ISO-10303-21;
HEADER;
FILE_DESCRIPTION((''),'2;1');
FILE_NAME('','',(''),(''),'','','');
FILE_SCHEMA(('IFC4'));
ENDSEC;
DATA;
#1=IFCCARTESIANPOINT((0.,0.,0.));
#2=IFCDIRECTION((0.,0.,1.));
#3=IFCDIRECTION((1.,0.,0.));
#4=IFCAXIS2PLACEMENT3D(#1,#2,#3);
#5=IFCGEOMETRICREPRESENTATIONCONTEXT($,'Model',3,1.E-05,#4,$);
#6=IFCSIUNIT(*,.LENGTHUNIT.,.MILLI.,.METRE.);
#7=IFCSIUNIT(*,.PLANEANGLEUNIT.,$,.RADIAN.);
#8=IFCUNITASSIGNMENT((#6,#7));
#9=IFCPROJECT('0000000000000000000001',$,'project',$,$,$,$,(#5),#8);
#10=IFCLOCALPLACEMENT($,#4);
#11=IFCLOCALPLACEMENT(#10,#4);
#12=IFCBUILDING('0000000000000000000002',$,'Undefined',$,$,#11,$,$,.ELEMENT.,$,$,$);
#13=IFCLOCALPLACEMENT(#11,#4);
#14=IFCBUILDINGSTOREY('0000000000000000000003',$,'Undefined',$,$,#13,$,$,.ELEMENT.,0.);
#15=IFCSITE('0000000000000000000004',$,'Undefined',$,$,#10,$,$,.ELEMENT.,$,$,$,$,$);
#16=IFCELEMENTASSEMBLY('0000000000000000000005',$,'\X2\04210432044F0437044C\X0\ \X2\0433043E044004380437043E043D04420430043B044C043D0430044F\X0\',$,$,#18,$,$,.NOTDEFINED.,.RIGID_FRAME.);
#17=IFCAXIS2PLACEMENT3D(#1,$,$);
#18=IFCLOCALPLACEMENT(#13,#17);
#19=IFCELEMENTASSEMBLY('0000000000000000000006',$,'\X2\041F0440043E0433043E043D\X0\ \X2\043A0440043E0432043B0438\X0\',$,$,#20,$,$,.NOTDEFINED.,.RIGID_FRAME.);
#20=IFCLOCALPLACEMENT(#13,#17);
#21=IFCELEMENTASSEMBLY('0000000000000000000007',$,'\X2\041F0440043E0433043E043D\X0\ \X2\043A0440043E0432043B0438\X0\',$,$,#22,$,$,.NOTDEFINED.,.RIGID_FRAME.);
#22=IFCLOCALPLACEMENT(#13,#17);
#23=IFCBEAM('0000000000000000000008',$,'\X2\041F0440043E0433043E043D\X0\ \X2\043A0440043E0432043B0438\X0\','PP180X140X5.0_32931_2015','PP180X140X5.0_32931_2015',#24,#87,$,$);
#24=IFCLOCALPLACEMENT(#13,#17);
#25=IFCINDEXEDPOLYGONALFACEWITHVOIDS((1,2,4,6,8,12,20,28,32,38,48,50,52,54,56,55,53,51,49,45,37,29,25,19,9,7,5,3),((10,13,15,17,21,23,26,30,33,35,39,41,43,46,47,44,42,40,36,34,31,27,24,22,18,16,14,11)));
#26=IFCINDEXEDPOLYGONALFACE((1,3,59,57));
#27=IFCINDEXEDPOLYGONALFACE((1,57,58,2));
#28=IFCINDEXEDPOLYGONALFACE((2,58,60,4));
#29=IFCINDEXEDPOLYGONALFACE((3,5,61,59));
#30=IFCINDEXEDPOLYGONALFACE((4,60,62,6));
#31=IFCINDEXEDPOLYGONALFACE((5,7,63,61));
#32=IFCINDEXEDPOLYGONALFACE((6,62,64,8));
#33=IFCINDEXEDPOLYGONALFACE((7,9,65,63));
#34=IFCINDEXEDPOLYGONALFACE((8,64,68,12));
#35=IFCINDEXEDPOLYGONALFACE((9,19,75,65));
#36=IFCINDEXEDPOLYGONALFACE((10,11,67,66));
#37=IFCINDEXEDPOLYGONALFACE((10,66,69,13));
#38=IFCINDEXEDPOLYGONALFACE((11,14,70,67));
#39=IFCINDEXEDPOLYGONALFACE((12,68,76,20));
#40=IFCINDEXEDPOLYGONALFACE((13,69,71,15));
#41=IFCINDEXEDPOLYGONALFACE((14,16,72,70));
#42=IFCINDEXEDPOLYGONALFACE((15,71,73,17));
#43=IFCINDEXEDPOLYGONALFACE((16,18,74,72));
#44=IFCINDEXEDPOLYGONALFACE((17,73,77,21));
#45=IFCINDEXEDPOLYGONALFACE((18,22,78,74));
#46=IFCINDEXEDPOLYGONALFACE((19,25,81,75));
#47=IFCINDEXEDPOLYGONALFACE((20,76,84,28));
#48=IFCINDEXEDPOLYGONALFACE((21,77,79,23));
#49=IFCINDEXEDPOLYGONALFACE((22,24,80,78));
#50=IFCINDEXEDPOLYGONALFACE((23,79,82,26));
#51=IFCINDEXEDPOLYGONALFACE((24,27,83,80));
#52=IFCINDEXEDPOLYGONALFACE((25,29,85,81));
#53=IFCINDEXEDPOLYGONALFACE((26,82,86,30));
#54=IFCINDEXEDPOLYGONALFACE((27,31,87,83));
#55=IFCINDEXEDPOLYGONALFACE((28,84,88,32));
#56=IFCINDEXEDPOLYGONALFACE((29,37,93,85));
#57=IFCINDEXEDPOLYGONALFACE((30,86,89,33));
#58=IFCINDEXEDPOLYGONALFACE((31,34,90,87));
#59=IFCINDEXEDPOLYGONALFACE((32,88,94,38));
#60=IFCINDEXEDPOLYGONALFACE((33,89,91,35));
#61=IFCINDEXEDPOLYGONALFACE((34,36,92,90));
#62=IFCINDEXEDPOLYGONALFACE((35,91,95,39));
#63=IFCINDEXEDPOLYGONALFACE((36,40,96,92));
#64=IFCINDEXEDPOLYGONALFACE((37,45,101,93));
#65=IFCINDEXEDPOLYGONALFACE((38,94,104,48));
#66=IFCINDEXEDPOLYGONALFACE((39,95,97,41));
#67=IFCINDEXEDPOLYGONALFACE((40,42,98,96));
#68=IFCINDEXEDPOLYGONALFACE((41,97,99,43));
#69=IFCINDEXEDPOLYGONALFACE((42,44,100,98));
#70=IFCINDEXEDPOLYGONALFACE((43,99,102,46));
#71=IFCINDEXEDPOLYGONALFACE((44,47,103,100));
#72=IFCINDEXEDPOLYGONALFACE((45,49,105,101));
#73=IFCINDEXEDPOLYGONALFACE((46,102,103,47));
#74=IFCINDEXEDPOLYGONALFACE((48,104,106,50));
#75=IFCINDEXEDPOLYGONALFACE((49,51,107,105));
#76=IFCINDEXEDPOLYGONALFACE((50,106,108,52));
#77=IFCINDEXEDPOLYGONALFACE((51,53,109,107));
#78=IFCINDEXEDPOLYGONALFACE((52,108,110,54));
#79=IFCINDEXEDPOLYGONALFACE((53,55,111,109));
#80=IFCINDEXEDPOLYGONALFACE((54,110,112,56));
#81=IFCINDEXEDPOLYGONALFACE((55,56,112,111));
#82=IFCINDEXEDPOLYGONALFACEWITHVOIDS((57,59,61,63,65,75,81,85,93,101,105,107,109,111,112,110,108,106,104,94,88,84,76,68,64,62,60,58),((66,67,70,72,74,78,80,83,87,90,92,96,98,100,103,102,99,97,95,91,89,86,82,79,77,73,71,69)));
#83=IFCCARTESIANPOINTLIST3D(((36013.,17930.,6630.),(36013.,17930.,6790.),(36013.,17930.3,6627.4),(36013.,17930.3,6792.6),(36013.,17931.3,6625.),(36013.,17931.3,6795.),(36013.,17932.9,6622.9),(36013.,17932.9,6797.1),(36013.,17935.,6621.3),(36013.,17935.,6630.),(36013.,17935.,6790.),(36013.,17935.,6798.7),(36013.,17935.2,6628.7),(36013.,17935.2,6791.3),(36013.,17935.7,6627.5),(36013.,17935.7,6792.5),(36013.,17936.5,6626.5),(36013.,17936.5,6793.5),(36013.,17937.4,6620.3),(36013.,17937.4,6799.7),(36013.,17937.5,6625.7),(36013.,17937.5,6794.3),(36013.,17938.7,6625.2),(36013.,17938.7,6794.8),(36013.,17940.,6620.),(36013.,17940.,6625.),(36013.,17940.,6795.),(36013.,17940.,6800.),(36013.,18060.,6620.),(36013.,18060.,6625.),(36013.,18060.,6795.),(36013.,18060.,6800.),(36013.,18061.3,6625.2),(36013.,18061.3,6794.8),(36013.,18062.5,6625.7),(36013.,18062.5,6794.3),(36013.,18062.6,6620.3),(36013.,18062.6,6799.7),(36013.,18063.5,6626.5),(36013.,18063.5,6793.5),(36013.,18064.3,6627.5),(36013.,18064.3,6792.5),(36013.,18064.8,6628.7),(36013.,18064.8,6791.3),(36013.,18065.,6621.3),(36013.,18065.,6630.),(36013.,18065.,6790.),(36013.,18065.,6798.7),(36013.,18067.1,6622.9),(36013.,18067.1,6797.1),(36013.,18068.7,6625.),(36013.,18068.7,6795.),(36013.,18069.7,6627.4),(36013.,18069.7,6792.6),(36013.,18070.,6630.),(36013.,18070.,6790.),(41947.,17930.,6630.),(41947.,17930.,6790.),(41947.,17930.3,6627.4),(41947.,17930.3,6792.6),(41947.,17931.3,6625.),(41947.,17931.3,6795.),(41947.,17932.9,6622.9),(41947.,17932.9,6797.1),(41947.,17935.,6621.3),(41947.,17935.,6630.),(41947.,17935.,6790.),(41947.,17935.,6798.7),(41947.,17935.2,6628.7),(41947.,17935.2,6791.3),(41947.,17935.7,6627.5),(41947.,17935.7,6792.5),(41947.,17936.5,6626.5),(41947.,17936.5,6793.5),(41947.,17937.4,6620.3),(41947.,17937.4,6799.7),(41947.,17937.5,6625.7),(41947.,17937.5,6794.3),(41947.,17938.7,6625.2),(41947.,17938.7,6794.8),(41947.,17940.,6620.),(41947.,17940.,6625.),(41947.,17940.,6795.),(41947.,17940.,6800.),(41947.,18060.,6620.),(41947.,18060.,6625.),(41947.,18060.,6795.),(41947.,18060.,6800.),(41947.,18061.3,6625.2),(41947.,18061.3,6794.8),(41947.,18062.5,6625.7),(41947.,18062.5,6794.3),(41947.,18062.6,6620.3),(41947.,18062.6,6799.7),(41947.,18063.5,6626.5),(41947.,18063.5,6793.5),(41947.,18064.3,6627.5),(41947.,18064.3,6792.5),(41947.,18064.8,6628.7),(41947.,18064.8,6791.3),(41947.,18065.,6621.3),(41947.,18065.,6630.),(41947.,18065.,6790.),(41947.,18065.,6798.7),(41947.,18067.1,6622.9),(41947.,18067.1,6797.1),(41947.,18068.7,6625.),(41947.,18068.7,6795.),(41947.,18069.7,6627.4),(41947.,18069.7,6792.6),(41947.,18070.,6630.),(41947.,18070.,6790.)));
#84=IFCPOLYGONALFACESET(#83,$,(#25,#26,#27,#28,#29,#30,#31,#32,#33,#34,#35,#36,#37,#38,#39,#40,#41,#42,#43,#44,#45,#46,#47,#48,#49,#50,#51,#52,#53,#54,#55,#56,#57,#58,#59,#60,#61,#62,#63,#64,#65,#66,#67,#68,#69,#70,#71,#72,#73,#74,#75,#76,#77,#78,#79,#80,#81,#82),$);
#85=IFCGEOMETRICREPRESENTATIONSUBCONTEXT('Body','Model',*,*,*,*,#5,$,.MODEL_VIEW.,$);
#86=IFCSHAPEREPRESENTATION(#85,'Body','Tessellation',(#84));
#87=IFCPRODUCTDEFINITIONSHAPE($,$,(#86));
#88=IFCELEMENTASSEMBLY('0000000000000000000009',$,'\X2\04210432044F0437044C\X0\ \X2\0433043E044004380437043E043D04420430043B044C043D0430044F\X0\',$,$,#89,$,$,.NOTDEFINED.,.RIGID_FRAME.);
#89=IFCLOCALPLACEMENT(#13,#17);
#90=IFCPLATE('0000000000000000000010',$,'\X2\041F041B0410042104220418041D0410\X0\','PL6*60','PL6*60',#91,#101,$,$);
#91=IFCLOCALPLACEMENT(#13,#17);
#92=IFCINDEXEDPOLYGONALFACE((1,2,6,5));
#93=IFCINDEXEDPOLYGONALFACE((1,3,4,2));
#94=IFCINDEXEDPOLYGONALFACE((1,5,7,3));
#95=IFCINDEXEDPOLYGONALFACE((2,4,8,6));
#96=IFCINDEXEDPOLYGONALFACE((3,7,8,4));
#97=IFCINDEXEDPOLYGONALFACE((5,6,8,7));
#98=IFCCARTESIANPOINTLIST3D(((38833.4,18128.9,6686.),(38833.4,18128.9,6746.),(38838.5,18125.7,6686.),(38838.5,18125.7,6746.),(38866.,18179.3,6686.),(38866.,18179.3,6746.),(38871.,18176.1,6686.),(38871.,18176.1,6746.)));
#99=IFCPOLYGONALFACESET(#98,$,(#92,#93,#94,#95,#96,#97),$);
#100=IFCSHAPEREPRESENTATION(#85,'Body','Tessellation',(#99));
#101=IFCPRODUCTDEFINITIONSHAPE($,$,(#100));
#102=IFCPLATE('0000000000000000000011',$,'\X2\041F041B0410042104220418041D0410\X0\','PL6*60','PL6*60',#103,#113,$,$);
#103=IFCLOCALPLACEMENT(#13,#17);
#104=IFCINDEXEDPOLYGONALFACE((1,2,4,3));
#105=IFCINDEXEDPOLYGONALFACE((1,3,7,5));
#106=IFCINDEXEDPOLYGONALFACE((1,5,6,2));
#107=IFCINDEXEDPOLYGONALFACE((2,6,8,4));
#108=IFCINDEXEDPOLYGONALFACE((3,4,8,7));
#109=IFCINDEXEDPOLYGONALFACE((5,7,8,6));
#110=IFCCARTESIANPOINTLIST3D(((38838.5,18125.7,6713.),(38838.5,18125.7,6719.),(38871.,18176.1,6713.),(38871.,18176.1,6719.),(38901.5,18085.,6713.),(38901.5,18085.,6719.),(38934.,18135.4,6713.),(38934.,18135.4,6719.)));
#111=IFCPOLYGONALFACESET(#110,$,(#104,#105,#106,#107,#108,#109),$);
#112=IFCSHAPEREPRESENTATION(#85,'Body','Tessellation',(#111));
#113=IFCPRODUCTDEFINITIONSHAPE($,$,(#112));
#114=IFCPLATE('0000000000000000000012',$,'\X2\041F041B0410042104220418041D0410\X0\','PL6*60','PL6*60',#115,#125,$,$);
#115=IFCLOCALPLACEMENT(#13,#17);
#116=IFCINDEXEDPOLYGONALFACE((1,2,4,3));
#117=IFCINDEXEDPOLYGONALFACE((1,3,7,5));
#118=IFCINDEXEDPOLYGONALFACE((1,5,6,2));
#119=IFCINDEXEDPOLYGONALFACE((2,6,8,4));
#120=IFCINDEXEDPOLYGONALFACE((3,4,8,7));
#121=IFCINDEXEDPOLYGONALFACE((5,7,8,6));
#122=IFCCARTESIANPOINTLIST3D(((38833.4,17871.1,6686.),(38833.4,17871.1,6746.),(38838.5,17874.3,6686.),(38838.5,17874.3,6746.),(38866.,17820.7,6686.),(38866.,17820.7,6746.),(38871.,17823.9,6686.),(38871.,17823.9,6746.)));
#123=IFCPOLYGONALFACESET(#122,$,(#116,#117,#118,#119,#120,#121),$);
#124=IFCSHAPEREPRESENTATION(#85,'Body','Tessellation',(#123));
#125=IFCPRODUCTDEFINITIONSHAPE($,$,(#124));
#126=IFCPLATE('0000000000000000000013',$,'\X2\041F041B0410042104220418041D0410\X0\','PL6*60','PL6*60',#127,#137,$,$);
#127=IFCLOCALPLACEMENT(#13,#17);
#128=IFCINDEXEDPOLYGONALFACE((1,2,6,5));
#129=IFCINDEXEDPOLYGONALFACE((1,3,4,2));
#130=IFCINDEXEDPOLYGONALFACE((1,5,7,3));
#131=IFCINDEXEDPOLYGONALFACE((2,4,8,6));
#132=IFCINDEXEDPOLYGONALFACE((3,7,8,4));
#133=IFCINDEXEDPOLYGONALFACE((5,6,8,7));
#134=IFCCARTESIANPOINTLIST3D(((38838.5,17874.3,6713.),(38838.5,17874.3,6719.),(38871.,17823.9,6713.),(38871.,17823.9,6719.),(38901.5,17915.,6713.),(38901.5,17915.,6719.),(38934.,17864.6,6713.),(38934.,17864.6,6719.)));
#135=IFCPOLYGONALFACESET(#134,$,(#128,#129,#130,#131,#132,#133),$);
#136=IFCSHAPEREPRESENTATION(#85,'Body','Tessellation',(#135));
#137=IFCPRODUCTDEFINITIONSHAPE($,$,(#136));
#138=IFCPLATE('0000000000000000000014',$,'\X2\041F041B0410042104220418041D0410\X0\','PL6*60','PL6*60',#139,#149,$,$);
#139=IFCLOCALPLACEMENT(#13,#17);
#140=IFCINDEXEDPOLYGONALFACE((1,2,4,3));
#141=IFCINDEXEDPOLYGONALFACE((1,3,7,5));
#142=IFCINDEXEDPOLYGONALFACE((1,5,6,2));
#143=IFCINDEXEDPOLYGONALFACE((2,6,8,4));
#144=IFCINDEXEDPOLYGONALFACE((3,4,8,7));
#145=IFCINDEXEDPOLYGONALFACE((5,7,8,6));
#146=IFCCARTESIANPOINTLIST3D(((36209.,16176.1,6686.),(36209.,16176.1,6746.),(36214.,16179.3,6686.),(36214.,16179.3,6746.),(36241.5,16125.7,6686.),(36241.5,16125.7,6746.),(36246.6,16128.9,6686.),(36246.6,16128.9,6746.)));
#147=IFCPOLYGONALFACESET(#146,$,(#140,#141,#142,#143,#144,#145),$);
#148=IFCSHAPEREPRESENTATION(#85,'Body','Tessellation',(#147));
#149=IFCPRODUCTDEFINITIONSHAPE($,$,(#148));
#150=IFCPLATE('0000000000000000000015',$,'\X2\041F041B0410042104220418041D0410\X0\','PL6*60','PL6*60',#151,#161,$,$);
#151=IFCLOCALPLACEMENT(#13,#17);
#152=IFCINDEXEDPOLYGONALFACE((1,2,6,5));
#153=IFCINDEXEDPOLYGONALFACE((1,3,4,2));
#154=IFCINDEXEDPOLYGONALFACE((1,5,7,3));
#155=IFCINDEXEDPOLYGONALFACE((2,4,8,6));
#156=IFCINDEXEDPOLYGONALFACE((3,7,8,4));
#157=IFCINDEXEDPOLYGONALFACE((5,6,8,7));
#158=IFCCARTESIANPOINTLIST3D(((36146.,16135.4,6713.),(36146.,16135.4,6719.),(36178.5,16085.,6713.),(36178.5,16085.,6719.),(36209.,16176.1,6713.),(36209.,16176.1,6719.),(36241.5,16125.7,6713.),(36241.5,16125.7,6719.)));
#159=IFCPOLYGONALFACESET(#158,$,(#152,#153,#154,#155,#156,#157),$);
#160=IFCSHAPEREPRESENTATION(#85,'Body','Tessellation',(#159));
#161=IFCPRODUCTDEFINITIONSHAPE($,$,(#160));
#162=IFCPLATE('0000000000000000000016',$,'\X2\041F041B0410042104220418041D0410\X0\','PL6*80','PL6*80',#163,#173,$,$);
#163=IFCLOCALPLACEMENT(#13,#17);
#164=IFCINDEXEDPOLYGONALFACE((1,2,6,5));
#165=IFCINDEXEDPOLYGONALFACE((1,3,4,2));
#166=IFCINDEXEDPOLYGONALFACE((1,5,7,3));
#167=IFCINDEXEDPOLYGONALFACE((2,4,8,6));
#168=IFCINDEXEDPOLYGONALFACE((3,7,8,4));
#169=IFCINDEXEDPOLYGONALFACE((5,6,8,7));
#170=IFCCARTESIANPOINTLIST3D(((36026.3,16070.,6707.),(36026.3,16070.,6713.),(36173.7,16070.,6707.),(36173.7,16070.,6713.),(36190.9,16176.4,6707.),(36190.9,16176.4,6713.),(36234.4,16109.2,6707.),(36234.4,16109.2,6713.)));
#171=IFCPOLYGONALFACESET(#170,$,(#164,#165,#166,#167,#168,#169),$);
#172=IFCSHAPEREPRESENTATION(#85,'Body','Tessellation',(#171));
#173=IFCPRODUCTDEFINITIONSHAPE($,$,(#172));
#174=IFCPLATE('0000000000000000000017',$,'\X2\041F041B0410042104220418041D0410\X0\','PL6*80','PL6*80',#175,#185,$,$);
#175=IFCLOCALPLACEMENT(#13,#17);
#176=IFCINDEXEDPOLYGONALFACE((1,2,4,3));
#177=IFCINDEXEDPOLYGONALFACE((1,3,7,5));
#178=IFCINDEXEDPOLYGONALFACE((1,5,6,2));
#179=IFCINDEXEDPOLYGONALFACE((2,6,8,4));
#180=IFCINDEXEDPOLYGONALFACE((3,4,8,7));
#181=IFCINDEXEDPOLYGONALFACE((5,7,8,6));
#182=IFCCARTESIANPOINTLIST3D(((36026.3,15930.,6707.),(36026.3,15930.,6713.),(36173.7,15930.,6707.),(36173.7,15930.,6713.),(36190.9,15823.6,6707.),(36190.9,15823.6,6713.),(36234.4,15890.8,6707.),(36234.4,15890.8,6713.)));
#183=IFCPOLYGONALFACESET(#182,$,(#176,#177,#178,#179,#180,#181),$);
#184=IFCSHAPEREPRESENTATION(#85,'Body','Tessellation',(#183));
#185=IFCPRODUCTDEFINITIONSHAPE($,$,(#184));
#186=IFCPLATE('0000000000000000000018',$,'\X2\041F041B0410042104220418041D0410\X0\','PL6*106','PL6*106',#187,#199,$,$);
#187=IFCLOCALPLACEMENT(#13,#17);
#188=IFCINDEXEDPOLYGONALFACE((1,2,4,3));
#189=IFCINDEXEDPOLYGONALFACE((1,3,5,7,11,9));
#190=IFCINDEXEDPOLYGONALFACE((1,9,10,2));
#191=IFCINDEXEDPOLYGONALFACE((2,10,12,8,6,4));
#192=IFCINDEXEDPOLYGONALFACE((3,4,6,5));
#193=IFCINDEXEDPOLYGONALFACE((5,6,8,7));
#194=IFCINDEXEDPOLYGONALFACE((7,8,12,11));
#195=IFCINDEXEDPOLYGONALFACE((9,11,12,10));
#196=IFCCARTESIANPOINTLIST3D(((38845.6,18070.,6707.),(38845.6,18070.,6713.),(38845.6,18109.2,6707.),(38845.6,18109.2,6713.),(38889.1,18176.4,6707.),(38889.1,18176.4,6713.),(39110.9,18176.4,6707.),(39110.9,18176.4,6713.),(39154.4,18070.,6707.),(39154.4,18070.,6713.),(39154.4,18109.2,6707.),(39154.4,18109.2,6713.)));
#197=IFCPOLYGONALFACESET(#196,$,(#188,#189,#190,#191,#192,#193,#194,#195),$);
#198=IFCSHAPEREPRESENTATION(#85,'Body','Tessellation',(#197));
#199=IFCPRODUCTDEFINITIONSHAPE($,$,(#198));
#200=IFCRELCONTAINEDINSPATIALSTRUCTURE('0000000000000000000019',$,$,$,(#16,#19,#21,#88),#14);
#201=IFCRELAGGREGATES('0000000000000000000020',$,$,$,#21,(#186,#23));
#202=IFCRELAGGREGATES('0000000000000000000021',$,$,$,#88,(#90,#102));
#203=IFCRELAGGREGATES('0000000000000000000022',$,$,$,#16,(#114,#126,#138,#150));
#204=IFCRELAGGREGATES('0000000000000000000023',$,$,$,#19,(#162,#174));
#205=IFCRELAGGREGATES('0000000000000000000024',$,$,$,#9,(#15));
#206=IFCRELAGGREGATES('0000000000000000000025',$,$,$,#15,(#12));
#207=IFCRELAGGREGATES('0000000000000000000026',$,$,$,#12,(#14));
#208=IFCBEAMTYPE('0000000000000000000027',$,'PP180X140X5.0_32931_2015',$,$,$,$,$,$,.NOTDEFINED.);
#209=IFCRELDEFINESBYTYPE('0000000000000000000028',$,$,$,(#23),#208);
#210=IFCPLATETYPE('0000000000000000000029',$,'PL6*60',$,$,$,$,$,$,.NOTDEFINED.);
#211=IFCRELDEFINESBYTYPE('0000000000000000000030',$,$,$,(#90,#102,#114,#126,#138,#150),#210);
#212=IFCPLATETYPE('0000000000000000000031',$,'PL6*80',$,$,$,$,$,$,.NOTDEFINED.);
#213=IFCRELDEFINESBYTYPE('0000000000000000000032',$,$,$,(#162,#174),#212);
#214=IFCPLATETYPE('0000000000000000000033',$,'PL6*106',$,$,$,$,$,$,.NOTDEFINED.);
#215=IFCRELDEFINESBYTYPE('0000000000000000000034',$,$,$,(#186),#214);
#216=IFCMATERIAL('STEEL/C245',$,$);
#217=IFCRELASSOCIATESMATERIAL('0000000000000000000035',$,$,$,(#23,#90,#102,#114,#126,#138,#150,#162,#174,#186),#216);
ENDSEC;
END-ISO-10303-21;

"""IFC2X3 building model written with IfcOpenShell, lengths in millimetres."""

from ifc_helpers import new_model, si_unit, frame, origin_with_axes, origin_2d_with_axis, place, context, subcontext, project, spatial, polyline, hollow_rectangle, outline, extrude, clip, halfspace, material, type_object, element, aggregate, save


model = new_model("IFC2X3")

# Units and contexts
model_context = context("Model", 3, precision=1e-05, world=origin_with_axes())
body_context = subcontext(model_context, "Body", "Model", "MODEL_VIEW")
ifc_project = project(units=[si_unit("LENGTHUNIT", "METRE", prefix="MILLI"), si_unit("PLANEANGLEUNIT", "RADIAN")], contexts=[model_context])

# Site, building, storey
site_placement = place(None, origin_with_axes())
site = spatial("IfcSite", under=ifc_project, at=site_placement, Name="Undefined", CompositionType="ELEMENT")
building_placement = place(site_placement, origin_with_axes())
building = spatial("IfcBuilding", under=site, at=building_placement, Name="Undefined", CompositionType="ELEMENT")
storey_placement = place(building_placement, origin_with_axes())
storey = spatial("IfcBuildingStorey", under=building, at=storey_placement, Name="Undefined", CompositionType="ELEMENT", Elevation=0.0)

# Element assembly
assembly_1_placement = place(storey_placement, origin_with_axes())
assembly_1 = element("IfcElementAssembly", 1, at=assembly_1_placement, inside=storey, Name="Связь горизонтальная", AssemblyPlace="NOTDEFINED", PredefinedType="RIGID_FRAME")
ifc_material_1 = material(Name="STEEL/C245")

# Element assembly
assembly_2_placement = place(storey_placement, origin_with_axes())
assembly_2 = element("IfcElementAssembly", 2, at=assembly_2_placement, inside=storey, Name="Прогон кровли", AssemblyPlace="NOTDEFINED", PredefinedType="RIGID_FRAME")

# Shared definitions
beam_type_1 = type_object("IfcBeamType", Name="PP180X140X5.0_32931_2015", PredefinedType="NOTDEFINED")

# Element assembly, beam
assembly_3_placement = place(storey_placement, origin_with_axes())
assembly_3 = element("IfcElementAssembly", 3, at=assembly_3_placement, inside=storey, Name="Прогон кровли", AssemblyPlace="NOTDEFINED", PredefinedType="RIGID_FRAME")
beam_1_placement = place(assembly_3_placement, frame((36013.0, 18000.0, 6710.0), z_axis=(0.0, 0.0, 1.0), x_axis=(1.0, 0.0, 0.0)))
beam_1 = element("IfcBeam", 4, at=beam_1_placement, type_object=beam_type_1, material=ifc_material_1, Name="Прогон кровли", Description="PP180X140X5.0_32931_2015", ObjectType="PP180X140X5.0_32931_2015", context=body_context, shape_type="Clipping", body=[
    clip(extrude(hollow_rectangle(XDim=140.0, YDim=180.0, WallThickness=5.0, InnerFilletRadius=5.0, OuterFilletRadius=10.0, at=origin_2d_with_axis()), frame((5934.0, 0.0, 0.0), z_axis=(-1.0, 0.0, 0.0), x_axis=(0.0, -1.0, 0.0)), (0.0, 0.0, 1.0), 5934.0), halfspace(frame((5934.0, 101.9, 90.0), z_axis=(1.0, 0.0, 0.0), x_axis=(0.0, -1.0, 0.0)), False)),
])

# Element assembly, plates
assembly_4_placement = place(storey_placement, origin_with_axes())
assembly_4 = element("IfcElementAssembly", 5, at=assembly_4_placement, inside=storey, Name="Связь горизонтальная", AssemblyPlace="NOTDEFINED", PredefinedType="RIGID_FRAME")
plate_type_1 = type_object("IfcPlateType", Name="PL6*60", PredefinedType="NOTDEFINED")
plate_1_placement = place(assembly_4_placement, frame((38852.2, 18152.5, 6686.0), z_axis=(0.840039, -0.542525, 0.0), x_axis=(0.0, 0.0, 1.0)))
plate_1 = element("IfcPlate", 6, at=plate_1_placement, type_object=plate_type_1, material=ifc_material_1, Name="ПЛАСТИНА", Description="PL6*60", ObjectType="PL6*60", context=body_context, shape_type="SweptSolid", body=[
    extrude(outline(polyline([(0.0, 30.0), (60.0, 30.0), (60.0, -30.0), (0.0, -30.0), (0.0, 30.0)])), frame((0.0, 0.0, -3.0), z_axis=(0.0, 0.0, 1.0), x_axis=(1.0, 0.0, 0.0)), (0.0, 0.0, 1.0), 6.0),
])
plate_2_placement = place(assembly_4_placement, frame((38917.8, 18110.2, 6716.0), z_axis=(0.0, 0.0, -1.0), x_axis=(-0.840039, 0.542525, 0.0)))
plate_2 = element("IfcPlate", 7, at=plate_2_placement, type_object=plate_type_1, material=ifc_material_1, Name="ПЛАСТИНА", Description="PL6*60", ObjectType="PL6*60", context=body_context, shape_type="SweptSolid", body=[
    extrude(outline(polyline([(75.0, -30.0), (0.0, -30.0), (0.0, 30.0), (75.0, 30.0), (75.0, -30.0)])), frame((0.0, 0.0, -3.0), z_axis=(0.0, 0.0, 1.0), x_axis=(1.0, 0.0, 0.0)), (0.0, 0.0, 1.0), 6.0),
])

# Plates
plate_3_placement = place(assembly_1_placement, frame((38852.2, 17847.5, 6686.0), z_axis=(0.840039, 0.542525, 0.0), x_axis=(0.0, 0.0, 1.0)))
plate_3 = element("IfcPlate", 8, at=plate_3_placement, type_object=plate_type_1, material=ifc_material_1, Name="ПЛАСТИНА", Description="PL6*60", ObjectType="PL6*60", context=body_context, shape_type="SweptSolid", body=[
    extrude(outline(polyline([(0.0, -30.0), (0.0, 30.0), (60.0, 30.0), (60.0, -30.0), (0.0, -30.0)])), frame((0.0, 0.0, -3.0), z_axis=(0.0, 0.0, 1.0), x_axis=(1.0, 0.0, 0.0)), (0.0, 0.0, 1.0), 6.0),
])
plate_4_placement = place(assembly_1_placement, frame((38917.8, 17889.8, 6716.0), z_axis=(0.0, 0.0, -1.0), x_axis=(-0.840039, -0.542525, 0.0)))
plate_4 = element("IfcPlate", 9, at=plate_4_placement, type_object=plate_type_1, material=ifc_material_1, Name="ПЛАСТИНА", Description="PL6*60", ObjectType="PL6*60", context=body_context, shape_type="SweptSolid", body=[
    extrude(outline(polyline([(75.0, 30.0), (75.0, -30.0), (0.0, -30.0), (0.0, 30.0), (75.0, 30.0)])), frame((0.0, 0.0, -3.0), z_axis=(0.0, 0.0, 1.0), x_axis=(1.0, 0.0, 0.0)), (0.0, 0.0, 1.0), 6.0),
])
plate_5_placement = place(assembly_1_placement, frame((36227.8, 16152.5, 6686.0), z_axis=(-0.840039, -0.542525, 0.0), x_axis=(0.0, 0.0, 1.0)))
plate_5 = element("IfcPlate", 10, at=plate_5_placement, type_object=plate_type_1, material=ifc_material_1, Name="ПЛАСТИНА", Description="PL6*60", ObjectType="PL6*60", context=body_context, shape_type="SweptSolid", body=[
    extrude(outline(polyline([(0.0, 30.0), (60.0, 30.0), (60.0, -30.0), (0.0, -30.0), (0.0, 30.0)])), frame((0.0, 0.0, -3.0), z_axis=(0.0, 0.0, 1.0), x_axis=(1.0, 0.0, 0.0)), (0.0, 0.0, 1.0), 6.0),
])
plate_6_placement = place(assembly_1_placement, frame((36162.2, 16110.2, 6716.0), z_axis=(0.0, 0.0, -1.0), x_axis=(0.840039, 0.542525, 0.0)))
plate_6 = element("IfcPlate", 11, at=plate_6_placement, type_object=plate_type_1, material=ifc_material_1, Name="ПЛАСТИНА", Description="PL6*60", ObjectType="PL6*60", context=body_context, shape_type="SweptSolid", body=[
    extrude(outline(polyline([(0.0, -30.0), (0.0, 30.0), (75.0, 30.0), (75.0, -30.0), (0.0, -30.0)])), frame((0.0, 0.0, -3.0), z_axis=(0.0, 0.0, 1.0), x_axis=(1.0, 0.0, 0.0)), (0.0, 0.0, 1.0), 6.0),
])
plate_type_2 = type_object("IfcPlateType", Name="PL6*80", PredefinedType="NOTDEFINED")
plate_7_placement = place(assembly_2_placement, frame((36026.3, 16070.0, 6710.0), z_axis=(0.0, 0.0, -1.0), x_axis=(0.840039, 0.542525, 0.0)))
plate_7 = element("IfcPlate", 12, at=plate_7_placement, type_object=plate_type_2, material=ifc_material_1, Name="ПЛАСТИНА", Description="PL6*80", ObjectType="PL6*80", context=body_context, shape_type="SweptSolid", body=[
    extrude(outline(polyline([(0.0, 0.0), (196.0, 0.0), (196.0, 80.0), (123.9, 80.0), (0.0, 0.0)])), frame((0.0, 0.0, -3.0), z_axis=(0.0, 0.0, 1.0), x_axis=(1.0, 0.0, 0.0)), (0.0, 0.0, 1.0), 6.0),
])
plate_8_placement = place(assembly_2_placement, frame((36026.3, 15930.0, 6710.0), z_axis=(0.0, 0.0, 1.0), x_axis=(0.840039, -0.542525, 0.0)))
plate_8 = element("IfcPlate", 13, at=plate_8_placement, type_object=plate_type_2, material=ifc_material_1, Name="ПЛАСТИНА", Description="PL6*80", ObjectType="PL6*80", context=body_context, shape_type="SweptSolid", body=[
    extrude(outline(polyline([(0.0, 0.0), (196.0, 0.0), (196.0, 80.0), (123.9, 80.0), (0.0, 0.0)])), frame((0.0, 0.0, -3.0), z_axis=(0.0, 0.0, 1.0), x_axis=(1.0, 0.0, 0.0)), (0.0, 0.0, 1.0), 6.0),
])
plate_type_3 = type_object("IfcPlateType", Name="PL6*106", PredefinedType="NOTDEFINED")
plate_9_placement = place(assembly_3_placement, frame((38845.6, 18070.0, 6710.0), z_axis=(0.0, 0.0, -1.0), x_axis=(0.0, 1.0, 0.0)))
plate_9 = element("IfcPlate", 14, at=plate_9_placement, type_object=plate_type_3, material=ifc_material_1, Name="ПЛАСТИНА", Description="PL6*106", ObjectType="PL6*106", context=body_context, shape_type="SweptSolid", body=[
    extrude(outline(polyline([(0.0, 0.0), (39.2, 0.0), (106.4, 43.4), (106.4, 265.3), (39.2, 308.7), (0.0, 308.7), (0.0, 0.0)])), frame((0.0, 0.0, -3.0), z_axis=(0.0, 0.0, 1.0), x_axis=(1.0, 0.0, 0.0)), (0.0, 0.0, 1.0), 6.0),
])
aggregate(assembly_3, [plate_9, beam_1])

aggregate(assembly_4, [plate_1, plate_2])
aggregate(assembly_1, [plate_3, plate_4, plate_5, plate_6])
aggregate(assembly_2, [plate_7, plate_8])

save(model, "model.ifc")
